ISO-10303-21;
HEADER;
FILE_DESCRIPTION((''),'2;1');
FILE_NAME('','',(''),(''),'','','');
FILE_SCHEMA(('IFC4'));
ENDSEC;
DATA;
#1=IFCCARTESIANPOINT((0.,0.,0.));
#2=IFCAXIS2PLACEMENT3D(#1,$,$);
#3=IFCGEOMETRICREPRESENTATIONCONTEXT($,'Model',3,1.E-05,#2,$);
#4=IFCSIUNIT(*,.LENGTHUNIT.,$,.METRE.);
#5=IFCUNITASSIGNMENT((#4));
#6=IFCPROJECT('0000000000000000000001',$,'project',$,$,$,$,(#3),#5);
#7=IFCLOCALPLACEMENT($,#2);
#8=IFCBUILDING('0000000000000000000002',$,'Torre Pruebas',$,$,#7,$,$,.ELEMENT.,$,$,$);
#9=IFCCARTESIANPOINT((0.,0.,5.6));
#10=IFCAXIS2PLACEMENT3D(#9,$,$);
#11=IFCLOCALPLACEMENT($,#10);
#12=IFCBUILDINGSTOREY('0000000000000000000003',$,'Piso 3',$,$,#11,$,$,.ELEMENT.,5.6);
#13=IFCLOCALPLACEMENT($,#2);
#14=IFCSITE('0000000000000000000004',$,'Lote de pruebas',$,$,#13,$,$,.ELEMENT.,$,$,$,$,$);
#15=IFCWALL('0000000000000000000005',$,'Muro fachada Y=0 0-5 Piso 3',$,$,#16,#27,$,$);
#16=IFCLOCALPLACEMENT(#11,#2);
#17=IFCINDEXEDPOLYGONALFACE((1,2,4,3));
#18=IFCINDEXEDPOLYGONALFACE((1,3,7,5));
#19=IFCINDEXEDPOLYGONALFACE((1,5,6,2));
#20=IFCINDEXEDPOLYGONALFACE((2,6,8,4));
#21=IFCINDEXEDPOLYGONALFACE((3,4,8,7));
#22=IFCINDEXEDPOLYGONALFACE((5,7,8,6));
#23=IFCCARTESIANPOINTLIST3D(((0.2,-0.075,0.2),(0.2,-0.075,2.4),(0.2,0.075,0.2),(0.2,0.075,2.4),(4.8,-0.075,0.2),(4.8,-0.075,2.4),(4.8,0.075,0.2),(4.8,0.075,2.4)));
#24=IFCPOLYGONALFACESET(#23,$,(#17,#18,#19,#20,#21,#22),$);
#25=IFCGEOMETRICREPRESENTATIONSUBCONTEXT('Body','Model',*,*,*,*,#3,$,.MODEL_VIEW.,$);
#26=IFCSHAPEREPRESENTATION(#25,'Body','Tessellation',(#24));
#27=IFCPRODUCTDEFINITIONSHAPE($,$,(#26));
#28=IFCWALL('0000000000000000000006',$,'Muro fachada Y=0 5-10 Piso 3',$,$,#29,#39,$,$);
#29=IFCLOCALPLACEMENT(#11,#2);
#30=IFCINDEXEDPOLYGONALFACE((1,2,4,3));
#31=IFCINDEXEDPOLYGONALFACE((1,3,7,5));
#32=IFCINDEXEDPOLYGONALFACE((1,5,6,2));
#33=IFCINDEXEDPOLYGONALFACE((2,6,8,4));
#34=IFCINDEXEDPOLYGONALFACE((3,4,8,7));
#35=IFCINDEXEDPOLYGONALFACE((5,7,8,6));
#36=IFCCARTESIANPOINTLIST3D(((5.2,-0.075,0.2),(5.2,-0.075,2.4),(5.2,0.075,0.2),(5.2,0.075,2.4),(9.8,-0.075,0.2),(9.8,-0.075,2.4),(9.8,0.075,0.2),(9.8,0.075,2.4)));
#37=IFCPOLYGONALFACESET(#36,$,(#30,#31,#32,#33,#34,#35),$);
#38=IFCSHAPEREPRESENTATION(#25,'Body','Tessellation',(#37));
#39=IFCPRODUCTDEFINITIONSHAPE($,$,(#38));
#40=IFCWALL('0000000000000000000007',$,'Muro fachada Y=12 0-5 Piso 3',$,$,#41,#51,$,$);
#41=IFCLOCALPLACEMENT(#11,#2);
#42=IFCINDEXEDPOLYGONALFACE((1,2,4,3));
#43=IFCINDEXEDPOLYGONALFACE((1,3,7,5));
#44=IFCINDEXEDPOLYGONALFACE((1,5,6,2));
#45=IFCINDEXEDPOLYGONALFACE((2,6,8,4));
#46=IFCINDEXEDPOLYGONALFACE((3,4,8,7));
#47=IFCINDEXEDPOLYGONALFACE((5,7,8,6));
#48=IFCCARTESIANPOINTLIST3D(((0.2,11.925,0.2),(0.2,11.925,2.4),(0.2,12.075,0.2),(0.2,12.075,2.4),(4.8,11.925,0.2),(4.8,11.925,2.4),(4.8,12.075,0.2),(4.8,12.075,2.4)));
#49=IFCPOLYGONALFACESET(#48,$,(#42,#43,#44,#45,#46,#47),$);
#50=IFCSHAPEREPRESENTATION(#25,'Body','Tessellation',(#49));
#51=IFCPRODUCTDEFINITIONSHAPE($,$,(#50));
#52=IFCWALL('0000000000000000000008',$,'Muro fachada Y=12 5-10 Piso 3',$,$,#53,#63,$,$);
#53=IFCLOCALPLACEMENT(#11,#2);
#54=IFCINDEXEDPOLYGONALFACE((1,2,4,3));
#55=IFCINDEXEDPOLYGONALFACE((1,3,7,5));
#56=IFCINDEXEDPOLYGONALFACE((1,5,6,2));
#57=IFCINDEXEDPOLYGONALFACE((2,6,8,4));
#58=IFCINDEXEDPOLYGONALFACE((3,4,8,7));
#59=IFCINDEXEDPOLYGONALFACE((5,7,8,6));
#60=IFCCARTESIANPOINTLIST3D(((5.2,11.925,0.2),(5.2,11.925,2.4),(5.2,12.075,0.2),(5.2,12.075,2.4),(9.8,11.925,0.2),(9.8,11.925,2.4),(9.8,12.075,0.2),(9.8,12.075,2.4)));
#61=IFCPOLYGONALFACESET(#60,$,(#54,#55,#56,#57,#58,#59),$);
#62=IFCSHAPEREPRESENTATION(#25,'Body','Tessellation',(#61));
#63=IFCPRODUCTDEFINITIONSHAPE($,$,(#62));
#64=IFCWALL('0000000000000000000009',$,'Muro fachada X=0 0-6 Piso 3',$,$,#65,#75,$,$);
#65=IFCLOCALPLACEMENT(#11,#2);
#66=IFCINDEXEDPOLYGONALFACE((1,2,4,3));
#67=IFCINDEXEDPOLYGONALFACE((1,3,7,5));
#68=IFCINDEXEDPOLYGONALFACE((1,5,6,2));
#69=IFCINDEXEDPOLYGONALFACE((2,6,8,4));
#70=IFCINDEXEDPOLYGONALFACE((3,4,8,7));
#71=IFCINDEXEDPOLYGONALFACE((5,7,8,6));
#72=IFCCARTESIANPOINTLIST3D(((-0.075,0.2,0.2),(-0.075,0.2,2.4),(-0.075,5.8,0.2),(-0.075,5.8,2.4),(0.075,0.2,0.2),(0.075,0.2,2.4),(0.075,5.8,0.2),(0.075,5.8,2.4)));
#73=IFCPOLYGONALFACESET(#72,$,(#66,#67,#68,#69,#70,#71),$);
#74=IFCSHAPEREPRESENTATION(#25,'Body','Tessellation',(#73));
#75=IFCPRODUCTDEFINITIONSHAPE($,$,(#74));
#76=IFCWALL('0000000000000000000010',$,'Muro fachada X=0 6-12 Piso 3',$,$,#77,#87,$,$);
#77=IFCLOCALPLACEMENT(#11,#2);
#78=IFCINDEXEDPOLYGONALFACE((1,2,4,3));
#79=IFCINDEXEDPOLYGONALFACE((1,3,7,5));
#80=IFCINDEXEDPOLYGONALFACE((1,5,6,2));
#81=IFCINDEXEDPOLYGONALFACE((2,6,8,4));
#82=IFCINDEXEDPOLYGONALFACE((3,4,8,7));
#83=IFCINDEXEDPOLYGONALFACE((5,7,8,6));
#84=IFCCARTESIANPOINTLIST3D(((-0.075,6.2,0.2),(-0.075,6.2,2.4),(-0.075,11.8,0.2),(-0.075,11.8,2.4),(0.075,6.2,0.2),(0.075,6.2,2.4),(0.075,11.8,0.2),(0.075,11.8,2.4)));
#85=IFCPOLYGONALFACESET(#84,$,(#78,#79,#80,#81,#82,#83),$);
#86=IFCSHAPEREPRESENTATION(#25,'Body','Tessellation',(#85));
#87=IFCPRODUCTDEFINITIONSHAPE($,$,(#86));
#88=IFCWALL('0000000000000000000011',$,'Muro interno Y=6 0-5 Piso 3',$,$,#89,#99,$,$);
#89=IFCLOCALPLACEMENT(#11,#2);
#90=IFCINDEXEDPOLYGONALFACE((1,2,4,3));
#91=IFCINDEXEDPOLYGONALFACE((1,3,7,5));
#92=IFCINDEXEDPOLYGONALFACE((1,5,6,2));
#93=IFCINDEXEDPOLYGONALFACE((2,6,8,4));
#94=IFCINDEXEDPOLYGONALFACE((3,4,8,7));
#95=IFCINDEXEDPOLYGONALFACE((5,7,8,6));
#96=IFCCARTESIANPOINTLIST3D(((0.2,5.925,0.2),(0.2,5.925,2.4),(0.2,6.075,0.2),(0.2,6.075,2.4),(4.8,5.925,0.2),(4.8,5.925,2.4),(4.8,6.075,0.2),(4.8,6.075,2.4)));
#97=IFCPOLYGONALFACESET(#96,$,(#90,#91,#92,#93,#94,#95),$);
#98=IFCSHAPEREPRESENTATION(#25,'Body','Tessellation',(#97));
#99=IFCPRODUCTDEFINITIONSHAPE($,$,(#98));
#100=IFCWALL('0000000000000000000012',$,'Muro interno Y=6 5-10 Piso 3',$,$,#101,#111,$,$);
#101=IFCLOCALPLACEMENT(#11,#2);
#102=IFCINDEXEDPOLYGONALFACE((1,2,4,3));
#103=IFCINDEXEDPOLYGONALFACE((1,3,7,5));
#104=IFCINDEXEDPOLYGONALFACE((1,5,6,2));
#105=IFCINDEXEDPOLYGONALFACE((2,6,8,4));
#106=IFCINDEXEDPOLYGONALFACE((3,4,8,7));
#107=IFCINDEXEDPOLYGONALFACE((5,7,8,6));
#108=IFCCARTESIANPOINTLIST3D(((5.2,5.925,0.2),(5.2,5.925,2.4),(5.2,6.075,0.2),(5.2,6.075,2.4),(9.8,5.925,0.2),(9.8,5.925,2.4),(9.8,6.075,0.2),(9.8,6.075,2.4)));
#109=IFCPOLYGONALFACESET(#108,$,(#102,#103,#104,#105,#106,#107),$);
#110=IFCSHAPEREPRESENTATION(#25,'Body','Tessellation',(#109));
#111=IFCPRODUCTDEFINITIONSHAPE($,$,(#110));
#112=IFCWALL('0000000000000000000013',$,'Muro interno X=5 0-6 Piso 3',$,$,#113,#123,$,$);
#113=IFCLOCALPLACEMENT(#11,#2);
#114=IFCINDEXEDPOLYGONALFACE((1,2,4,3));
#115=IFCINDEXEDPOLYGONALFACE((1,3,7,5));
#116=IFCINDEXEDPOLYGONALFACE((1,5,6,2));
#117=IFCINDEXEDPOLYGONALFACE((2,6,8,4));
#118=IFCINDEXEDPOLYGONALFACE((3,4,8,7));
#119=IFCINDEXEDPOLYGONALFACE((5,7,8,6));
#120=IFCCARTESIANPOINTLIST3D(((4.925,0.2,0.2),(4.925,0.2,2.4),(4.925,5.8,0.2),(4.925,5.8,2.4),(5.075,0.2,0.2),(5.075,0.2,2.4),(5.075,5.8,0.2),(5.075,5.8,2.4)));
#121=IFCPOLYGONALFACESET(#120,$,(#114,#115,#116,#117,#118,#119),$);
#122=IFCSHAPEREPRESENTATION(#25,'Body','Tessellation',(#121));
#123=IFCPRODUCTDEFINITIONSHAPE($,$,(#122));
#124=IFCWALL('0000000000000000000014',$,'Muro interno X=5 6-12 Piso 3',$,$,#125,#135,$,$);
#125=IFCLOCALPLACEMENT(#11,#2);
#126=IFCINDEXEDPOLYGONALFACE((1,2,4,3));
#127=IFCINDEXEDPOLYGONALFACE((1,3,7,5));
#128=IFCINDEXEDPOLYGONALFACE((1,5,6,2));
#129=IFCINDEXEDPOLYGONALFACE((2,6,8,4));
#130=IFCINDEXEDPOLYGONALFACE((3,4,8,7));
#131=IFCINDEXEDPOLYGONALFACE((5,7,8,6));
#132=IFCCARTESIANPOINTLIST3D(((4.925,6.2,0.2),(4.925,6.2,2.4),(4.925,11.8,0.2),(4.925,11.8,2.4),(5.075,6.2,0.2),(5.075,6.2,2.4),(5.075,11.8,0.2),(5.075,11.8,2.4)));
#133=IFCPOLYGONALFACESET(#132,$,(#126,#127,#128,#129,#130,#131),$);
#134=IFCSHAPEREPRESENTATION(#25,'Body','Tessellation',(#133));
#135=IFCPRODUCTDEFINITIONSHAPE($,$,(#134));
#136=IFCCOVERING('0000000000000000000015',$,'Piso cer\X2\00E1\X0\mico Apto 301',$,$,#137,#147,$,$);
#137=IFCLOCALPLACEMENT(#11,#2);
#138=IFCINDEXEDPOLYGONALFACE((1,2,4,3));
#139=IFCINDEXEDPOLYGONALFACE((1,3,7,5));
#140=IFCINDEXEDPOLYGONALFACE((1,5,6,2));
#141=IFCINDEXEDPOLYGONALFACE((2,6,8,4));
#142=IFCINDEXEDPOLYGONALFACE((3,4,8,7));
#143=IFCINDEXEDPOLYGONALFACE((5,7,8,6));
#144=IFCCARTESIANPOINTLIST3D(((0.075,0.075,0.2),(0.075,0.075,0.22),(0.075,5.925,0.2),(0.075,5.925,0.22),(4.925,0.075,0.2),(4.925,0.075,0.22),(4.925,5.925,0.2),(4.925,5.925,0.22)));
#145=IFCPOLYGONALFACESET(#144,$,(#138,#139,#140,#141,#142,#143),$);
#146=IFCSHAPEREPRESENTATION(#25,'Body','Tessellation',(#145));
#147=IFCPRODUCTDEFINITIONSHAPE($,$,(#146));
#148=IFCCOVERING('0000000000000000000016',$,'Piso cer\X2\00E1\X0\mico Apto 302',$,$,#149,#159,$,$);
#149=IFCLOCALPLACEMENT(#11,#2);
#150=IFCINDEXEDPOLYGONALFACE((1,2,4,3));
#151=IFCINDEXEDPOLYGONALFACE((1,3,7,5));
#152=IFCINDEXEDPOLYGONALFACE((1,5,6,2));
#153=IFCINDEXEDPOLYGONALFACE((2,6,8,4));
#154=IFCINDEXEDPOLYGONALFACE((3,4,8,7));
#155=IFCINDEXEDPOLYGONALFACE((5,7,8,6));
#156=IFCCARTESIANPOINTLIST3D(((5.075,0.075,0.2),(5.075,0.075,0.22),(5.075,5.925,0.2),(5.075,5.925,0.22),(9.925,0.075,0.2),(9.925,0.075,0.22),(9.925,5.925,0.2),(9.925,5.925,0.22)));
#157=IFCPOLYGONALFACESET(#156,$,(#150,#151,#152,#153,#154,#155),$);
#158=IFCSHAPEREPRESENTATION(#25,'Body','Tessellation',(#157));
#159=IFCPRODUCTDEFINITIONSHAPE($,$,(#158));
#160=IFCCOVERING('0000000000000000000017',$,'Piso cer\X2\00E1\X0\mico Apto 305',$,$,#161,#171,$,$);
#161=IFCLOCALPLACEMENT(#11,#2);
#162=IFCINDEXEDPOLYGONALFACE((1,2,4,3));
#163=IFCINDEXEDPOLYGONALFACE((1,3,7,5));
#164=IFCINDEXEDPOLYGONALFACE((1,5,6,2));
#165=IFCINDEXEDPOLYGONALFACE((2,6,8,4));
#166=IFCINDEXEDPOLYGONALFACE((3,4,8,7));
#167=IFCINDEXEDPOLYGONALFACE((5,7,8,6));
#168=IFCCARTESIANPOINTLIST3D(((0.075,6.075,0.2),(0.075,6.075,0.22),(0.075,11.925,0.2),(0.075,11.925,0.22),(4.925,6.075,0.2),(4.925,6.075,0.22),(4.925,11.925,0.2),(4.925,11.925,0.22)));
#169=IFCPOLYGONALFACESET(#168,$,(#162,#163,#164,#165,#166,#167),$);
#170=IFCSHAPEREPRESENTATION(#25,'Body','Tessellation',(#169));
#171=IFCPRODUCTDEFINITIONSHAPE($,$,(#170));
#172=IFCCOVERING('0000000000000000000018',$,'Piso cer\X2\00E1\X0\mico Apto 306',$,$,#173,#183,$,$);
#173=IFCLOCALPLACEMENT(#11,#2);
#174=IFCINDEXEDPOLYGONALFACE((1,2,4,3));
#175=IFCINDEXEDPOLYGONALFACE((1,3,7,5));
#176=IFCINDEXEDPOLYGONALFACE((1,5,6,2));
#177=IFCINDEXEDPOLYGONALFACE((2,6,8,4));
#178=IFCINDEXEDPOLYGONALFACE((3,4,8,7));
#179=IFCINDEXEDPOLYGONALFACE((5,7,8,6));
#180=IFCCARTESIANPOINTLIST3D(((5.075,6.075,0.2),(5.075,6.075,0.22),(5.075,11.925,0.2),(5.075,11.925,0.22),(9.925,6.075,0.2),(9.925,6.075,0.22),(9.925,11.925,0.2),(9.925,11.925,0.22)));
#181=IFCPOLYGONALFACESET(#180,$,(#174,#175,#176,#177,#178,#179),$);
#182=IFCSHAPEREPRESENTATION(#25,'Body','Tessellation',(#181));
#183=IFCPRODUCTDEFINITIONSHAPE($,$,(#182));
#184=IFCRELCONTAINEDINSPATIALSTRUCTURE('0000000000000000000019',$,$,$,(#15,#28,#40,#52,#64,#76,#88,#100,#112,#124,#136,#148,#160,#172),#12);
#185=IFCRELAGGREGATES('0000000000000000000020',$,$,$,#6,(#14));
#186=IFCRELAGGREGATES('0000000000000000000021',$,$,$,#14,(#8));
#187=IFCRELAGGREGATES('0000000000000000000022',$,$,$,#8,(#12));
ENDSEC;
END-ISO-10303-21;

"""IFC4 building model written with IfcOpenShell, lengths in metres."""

from ifc_helpers import new_model, si_unit, frame, origin, origin_2d, place, context, subcontext, project, spatial, rectangle, extrude, element, save


model = new_model("IFC4")

# Units and contexts
model_context = context("Model", 3, precision=1e-05, world=origin())
body_context = subcontext(model_context, "Body", "Model", "MODEL_VIEW")
ifc_project = project(units=[si_unit("LENGTHUNIT", "METRE")], contexts=[model_context])

# Site, building, storey
site_placement = place(None, origin())
site = spatial("IfcSite", under=ifc_project, at=site_placement, Name="Lote de pruebas", CompositionType="ELEMENT")
building_placement = place(None, origin())
building = spatial("IfcBuilding", under=site, at=building_placement, Name="Torre Pruebas", CompositionType="ELEMENT")
storey_placement = place(None, frame((0.0, 0.0, 5.6)))
storey = spatial("IfcBuildingStorey", under=building, at=storey_placement, Name="Piso 3", CompositionType="ELEMENT", Elevation=5.6)

# Walls
for number, where, name in (
    (1, (2.5, 0.0, 5.8), "Muro fachada Y=0 0-5 Piso 3"),
    (2, (7.5, 0.0, 5.8), "Muro fachada Y=0 5-10 Piso 3"),
    (3, (2.5, 12.0, 5.8), "Muro fachada Y=12 0-5 Piso 3"),
    (4, (7.5, 12.0, 5.8), "Muro fachada Y=12 5-10 Piso 3"),
):
    element("IfcWall", number, at=place(None, frame(where)), inside=storey, Name=name, context=body_context, shape_type="SweptSolid", body=[
        extrude(rectangle(XDim=4.6, YDim=0.15, at=origin_2d()), origin(), (0.0, 0.0, 1.0), 2.2),
    ])
for number, where, name in (
    (5, (0.0, 3.0, 5.8), "Muro fachada X=0 0-6 Piso 3"),
    (6, (0.0, 9.0, 5.8), "Muro fachada X=0 6-12 Piso 3"),
):
    element("IfcWall", number, at=place(None, frame(where)), inside=storey, Name=name, context=body_context, shape_type="SweptSolid", body=[
        extrude(rectangle(XDim=0.15, YDim=5.6, at=origin_2d()), origin(), (0.0, 0.0, 1.0), 2.2),
    ])
for number, where, name in (
    (7, (2.5, 6.0, 5.8), "Muro interno Y=6 0-5 Piso 3"),
    (8, (7.5, 6.0, 5.8), "Muro interno Y=6 5-10 Piso 3"),
):
    element("IfcWall", number, at=place(None, frame(where)), inside=storey, Name=name, context=body_context, shape_type="SweptSolid", body=[
        extrude(rectangle(XDim=4.6, YDim=0.15, at=origin_2d()), origin(), (0.0, 0.0, 1.0), 2.2),
    ])
for number, where, name in (
    (9, (5.0, 3.0, 5.8), "Muro interno X=5 0-6 Piso 3"),
    (10, (5.0, 9.0, 5.8), "Muro interno X=5 6-12 Piso 3"),
):
    element("IfcWall", number, at=place(None, frame(where)), inside=storey, Name=name, context=body_context, shape_type="SweptSolid", body=[
        extrude(rectangle(XDim=0.15, YDim=5.6, at=origin_2d()), origin(), (0.0, 0.0, 1.0), 2.2),
    ])

# Coverings
for number, where, name in (
    (11, (2.5, 3.0, 5.8), "Piso cerámico Apto 301"),
    (12, (7.5, 3.0, 5.8), "Piso cerámico Apto 302"),
    (13, (2.5, 9.0, 5.8), "Piso cerámico Apto 305"),
    (14, (7.5, 9.0, 5.8), "Piso cerámico Apto 306"),
):
    element("IfcCovering", number, at=place(None, frame(where)), inside=storey, Name=name, context=body_context, shape_type="SweptSolid", body=[
        extrude(rectangle(XDim=4.85, YDim=5.85, at=origin_2d()), origin(), (0.0, 0.0, 1.0), 0.02),
    ])

save(model, "model.ifc")
